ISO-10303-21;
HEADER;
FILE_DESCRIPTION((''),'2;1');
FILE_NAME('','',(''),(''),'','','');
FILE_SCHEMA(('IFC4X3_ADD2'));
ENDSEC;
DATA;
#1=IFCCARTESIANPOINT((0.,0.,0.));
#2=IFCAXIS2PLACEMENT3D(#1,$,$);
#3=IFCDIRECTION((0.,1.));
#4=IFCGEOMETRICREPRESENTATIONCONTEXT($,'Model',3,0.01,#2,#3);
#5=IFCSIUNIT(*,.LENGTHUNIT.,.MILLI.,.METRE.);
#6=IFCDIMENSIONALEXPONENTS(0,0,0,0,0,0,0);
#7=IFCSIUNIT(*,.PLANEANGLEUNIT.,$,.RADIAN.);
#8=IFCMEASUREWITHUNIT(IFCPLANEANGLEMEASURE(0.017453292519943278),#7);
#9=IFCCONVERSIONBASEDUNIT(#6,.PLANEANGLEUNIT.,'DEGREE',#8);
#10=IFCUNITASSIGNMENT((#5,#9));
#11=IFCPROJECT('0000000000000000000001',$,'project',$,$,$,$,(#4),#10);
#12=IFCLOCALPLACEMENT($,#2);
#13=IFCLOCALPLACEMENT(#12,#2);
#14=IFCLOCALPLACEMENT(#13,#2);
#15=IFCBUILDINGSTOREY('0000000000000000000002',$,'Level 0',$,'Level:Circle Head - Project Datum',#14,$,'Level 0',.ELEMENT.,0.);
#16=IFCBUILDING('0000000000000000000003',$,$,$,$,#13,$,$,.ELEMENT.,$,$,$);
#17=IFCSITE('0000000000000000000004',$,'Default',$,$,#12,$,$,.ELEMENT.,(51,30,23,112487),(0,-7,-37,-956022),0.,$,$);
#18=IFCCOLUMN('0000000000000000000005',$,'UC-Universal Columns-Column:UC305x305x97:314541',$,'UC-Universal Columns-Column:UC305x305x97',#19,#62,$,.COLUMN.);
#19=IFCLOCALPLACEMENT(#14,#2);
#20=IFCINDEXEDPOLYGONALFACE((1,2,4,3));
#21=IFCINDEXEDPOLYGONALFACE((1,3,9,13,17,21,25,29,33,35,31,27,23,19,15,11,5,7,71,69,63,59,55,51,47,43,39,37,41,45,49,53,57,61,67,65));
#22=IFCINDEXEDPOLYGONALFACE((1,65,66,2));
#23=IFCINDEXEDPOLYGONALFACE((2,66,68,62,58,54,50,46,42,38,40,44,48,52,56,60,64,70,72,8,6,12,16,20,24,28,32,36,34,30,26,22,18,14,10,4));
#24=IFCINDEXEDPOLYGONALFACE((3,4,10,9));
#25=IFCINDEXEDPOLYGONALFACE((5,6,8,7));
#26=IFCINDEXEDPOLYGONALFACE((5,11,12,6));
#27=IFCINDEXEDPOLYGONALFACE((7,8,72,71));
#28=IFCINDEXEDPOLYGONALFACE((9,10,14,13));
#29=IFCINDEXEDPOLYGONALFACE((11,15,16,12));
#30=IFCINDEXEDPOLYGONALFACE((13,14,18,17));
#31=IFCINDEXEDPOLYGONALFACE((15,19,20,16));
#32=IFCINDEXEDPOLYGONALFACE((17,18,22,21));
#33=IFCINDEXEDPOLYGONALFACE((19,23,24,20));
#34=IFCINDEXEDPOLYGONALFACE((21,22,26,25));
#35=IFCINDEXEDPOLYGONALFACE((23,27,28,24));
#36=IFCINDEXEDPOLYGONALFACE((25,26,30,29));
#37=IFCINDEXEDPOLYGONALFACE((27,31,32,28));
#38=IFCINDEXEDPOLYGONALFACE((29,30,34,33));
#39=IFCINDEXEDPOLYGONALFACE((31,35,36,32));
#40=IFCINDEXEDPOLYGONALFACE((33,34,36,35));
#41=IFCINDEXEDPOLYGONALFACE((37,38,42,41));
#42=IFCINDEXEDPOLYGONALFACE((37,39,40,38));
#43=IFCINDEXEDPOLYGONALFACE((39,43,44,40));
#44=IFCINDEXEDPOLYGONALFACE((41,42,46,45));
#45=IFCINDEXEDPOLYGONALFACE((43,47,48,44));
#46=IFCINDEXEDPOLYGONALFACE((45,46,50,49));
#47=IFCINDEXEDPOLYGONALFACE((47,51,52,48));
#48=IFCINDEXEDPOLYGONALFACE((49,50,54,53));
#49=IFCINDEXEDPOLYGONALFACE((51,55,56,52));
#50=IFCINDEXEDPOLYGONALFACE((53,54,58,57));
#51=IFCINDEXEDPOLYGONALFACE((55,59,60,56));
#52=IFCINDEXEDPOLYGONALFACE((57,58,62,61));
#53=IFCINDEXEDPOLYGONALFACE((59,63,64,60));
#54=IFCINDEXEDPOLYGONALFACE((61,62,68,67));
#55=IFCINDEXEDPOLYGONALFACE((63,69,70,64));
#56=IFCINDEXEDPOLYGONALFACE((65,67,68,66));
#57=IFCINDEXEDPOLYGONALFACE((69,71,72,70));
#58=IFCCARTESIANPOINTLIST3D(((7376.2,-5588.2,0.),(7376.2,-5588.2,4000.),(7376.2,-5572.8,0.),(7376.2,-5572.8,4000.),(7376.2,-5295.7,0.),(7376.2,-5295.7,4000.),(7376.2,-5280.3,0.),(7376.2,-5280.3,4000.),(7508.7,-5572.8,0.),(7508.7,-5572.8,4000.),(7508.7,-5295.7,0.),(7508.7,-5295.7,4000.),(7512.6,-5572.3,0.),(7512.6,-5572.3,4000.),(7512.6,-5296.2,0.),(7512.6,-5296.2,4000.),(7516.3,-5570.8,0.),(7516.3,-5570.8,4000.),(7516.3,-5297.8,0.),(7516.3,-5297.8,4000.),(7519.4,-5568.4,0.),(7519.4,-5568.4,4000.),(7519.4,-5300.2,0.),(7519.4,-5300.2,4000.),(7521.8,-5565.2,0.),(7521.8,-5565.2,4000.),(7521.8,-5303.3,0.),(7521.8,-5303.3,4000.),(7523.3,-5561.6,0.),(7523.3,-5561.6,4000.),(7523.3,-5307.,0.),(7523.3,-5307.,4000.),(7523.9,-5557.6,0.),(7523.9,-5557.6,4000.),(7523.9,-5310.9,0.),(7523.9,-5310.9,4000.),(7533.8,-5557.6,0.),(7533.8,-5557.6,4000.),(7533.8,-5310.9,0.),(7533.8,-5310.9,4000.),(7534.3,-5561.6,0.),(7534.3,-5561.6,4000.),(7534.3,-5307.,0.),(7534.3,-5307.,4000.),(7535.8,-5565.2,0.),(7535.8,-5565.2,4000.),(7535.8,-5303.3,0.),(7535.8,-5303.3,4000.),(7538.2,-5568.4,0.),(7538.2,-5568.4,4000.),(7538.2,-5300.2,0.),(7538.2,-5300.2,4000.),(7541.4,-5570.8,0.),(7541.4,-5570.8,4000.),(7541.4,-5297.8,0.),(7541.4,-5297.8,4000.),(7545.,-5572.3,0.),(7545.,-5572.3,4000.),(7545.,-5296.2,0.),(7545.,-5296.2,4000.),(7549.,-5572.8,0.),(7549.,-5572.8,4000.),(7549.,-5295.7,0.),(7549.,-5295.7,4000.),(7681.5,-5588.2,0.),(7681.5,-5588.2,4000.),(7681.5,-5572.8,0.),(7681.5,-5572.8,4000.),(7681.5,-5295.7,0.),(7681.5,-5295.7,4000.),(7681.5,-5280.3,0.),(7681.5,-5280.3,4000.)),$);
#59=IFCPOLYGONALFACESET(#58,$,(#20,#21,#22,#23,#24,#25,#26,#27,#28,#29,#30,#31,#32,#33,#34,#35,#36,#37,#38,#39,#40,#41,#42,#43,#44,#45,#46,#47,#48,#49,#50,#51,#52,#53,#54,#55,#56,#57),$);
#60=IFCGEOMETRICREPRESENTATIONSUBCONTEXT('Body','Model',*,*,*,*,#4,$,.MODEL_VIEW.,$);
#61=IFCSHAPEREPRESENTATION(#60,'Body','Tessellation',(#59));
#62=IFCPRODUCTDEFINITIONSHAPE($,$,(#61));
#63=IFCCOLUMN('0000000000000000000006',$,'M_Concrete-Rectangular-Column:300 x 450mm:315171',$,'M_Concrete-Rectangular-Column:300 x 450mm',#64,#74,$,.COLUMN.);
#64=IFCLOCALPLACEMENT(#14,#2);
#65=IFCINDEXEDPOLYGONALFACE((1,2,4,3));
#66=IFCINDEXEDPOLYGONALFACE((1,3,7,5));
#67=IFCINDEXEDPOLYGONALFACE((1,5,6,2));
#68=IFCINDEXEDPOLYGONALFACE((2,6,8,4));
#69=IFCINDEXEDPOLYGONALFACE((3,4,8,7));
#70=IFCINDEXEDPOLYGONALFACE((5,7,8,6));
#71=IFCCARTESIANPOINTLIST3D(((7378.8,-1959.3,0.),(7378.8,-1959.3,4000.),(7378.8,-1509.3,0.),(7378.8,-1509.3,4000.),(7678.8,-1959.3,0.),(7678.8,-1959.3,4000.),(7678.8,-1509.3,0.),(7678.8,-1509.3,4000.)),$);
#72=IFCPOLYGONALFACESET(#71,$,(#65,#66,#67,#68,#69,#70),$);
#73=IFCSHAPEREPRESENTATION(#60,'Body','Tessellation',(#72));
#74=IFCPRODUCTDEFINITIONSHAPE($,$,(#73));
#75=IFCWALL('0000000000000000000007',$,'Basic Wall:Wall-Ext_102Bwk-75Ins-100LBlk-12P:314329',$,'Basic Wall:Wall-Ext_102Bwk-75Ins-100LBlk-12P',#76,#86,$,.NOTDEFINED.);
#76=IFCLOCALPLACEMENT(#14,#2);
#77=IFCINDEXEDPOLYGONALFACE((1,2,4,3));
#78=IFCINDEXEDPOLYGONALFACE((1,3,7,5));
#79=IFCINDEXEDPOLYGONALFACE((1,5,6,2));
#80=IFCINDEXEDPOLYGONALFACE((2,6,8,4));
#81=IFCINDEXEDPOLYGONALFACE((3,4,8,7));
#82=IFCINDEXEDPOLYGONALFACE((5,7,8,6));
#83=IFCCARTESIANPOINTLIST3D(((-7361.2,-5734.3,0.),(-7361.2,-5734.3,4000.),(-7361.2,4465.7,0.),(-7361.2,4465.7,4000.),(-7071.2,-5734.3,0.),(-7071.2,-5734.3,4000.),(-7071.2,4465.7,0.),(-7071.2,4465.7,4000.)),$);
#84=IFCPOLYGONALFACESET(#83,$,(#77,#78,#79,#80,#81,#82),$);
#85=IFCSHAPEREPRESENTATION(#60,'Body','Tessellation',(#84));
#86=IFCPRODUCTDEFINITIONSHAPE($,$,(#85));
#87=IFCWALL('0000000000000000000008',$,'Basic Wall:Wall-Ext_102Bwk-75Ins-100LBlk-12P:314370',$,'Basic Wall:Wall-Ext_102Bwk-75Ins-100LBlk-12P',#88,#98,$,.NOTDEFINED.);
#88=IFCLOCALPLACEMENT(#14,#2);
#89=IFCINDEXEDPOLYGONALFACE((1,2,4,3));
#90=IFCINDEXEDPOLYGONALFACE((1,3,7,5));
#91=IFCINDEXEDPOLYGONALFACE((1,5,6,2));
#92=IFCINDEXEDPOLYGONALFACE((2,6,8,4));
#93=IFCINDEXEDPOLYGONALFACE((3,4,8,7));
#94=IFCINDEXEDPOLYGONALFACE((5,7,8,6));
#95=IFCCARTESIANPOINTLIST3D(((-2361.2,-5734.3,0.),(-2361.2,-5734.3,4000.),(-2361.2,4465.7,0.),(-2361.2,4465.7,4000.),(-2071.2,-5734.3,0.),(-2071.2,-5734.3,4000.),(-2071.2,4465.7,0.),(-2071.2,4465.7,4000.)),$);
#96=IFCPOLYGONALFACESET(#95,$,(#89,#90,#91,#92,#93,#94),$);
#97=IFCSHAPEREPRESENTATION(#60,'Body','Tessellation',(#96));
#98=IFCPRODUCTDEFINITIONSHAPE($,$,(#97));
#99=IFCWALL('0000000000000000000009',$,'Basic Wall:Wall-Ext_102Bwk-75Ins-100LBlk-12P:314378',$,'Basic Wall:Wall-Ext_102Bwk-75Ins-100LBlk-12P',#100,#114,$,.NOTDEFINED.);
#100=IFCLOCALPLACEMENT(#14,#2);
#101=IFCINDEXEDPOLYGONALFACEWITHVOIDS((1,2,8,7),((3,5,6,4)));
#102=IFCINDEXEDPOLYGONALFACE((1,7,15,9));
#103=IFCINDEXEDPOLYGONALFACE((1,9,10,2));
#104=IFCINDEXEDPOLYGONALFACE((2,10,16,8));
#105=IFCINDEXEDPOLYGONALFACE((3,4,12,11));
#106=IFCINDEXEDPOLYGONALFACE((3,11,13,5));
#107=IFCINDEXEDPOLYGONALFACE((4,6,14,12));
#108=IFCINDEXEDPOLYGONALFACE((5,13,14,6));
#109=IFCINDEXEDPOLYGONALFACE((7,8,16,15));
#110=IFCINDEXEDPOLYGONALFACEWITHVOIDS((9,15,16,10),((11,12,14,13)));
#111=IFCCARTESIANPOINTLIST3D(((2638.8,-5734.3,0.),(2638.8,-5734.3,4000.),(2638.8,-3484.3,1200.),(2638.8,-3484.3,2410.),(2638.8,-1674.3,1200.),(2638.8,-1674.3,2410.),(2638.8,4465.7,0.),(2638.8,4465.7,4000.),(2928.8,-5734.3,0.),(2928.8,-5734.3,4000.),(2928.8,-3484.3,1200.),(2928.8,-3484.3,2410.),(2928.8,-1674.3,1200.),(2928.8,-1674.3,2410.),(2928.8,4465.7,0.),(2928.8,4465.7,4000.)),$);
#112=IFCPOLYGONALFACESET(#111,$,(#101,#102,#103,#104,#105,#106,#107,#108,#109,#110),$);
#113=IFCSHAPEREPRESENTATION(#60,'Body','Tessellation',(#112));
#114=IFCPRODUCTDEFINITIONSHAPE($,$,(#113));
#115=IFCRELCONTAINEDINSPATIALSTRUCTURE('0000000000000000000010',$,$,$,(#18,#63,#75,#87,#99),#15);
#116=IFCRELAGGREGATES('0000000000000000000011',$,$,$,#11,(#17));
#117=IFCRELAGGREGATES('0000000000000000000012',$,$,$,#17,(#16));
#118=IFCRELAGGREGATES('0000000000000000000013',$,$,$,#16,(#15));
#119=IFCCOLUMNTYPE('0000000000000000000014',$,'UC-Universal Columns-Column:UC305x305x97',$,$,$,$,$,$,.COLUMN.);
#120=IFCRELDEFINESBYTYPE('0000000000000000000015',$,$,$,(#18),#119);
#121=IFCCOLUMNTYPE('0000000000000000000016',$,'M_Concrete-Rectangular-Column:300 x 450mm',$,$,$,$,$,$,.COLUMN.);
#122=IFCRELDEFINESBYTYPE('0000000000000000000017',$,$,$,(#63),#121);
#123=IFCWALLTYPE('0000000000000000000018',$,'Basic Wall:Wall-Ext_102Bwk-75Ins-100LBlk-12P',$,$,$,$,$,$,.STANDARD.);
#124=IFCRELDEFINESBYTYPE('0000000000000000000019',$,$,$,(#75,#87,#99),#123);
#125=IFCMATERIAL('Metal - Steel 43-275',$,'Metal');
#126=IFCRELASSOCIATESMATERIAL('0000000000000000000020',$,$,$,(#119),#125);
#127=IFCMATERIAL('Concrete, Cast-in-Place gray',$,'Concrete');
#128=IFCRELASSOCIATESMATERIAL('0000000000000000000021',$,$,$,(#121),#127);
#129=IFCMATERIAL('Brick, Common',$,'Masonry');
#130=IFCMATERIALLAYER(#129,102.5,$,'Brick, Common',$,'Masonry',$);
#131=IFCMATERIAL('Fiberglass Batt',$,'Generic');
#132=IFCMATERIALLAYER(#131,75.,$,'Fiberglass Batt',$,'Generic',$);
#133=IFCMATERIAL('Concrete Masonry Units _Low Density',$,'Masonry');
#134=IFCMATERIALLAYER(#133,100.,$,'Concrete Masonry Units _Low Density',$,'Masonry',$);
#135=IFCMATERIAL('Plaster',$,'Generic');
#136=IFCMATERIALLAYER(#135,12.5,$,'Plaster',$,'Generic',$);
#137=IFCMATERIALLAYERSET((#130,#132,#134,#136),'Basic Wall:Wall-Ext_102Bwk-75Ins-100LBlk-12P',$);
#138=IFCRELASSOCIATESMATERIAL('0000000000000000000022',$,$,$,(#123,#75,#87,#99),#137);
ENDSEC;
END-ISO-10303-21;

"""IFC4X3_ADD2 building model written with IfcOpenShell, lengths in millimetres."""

from ifc_helpers import new_model, entity, si_unit, converted_unit, direction, frame, frame_2d, origin, origin_2d_with_axis, place, context, subcontext, project, spatial, rectangle, i_section, extrude, source, transform, mapped, material, layer, layer_set, material_profile, profile_set, type_object, type_shapes, element, save


model = new_model("IFC4X3_ADD2")

# Units and contexts
model_context = context("Model", 3, precision=0.01, world=origin(), true_north=direction((0.0, 1.0)))
body_context = subcontext(model_context, "Body", "Model", "MODEL_VIEW")
ifc_project = project(units=[si_unit("LENGTHUNIT", "METRE", prefix="MILLI"), converted_unit("PLANEANGLEUNIT", "DEGREE", entity("IfcPlaneAngleMeasure", 0.017453292519943278), si_unit("PLANEANGLEUNIT", "RADIAN"), dimensions=[0, 0, 0, 0, 0, 0, 0])], contexts=[model_context])

# Site, building, storey
site_placement = place(None, origin())
site = spatial("IfcSite", under=ifc_project, at=site_placement, Name="Default", CompositionType="ELEMENT", RefLatitude=(51, 30, 23, 112487), RefLongitude=(0, -7, -37, -956022), RefElevation=0.0)
building_placement = place(site_placement, origin())
building = spatial("IfcBuilding", under=site, at=building_placement, CompositionType="ELEMENT")
storey_placement = place(building_placement, origin())
storey = spatial("IfcBuildingStorey", under=building, at=storey_placement, Name="Level 0", ObjectType="Level:Circle Head - Project Datum", LongName="Level 0", CompositionType="ELEMENT", Elevation=0.0)

# Columns
ifc_material_1 = material(Name="Metal - Steel 43-275", Category="Metal")
ifc_material_profile_1 = material_profile(ifc_material_1, i_section(OverallWidth=305.3, OverallDepth=307.9, WebThickness=9.9, FlangeThickness=15.4, FilletRadius=15.2, at=origin_2d_with_axis()), Name="UC305x305x97")
ifc_profile_set_1 = profile_set([ifc_material_profile_1], Name="UC305x305x97")
column_type_1 = type_object("IfcColumnType", Name="UC-Universal Columns-Column:UC305x305x97", PredefinedType="COLUMN", material=ifc_profile_set_1)
shared_shape_1 = source(origin(), body_context, "Body", "SweptSolid", [
    extrude(i_section(OverallWidth=305.3, OverallDepth=307.9, WebThickness=9.9, FlangeThickness=15.4, FilletRadius=15.2, at=origin_2d_with_axis()), frame((0.0, 0.0, 0.0), z_axis=(0.0, 0.0, 1.0), x_axis=(-1.0, 0.0, 0.0)), (0.0, 0.0, 1.0), 4000.0),
])
type_shapes(column_type_1, [shared_shape_1])
column_1_placement = place(storey_placement, frame((7528.8, -5434.3, 0.0)))
element("IfcColumn", 1, at=column_1_placement, inside=storey, type_object=column_type_1, Name="UC-Universal Columns-Column:UC305x305x97:314541", ObjectType="UC-Universal Columns-Column:UC305x305x97", PredefinedType="COLUMN", context=body_context, shape_type="MappedRepresentation", body=[
    mapped(shared_shape_1, transform((0.0, 0.0, 0.0), scale=1.0)),
])
ifc_material_2 = material(Name="Concrete, Cast-in-Place gray", Category="Concrete")
ifc_material_profile_2 = material_profile(ifc_material_2, rectangle(XDim=300.0, YDim=450.0, at=origin_2d_with_axis()), Name="300 x 450mm")
ifc_profile_set_2 = profile_set([ifc_material_profile_2], Name="300 x 450mm")
column_type_2 = type_object("IfcColumnType", Name="M_Concrete-Rectangular-Column:300 x 450mm", PredefinedType="COLUMN", material=ifc_profile_set_2)
shared_shape_2 = source(origin(), body_context, "Body", "SweptSolid", [
    extrude(rectangle(XDim=300.0, YDim=450.0, at=origin_2d_with_axis()), frame((0.0, 0.0, 0.0), z_axis=(0.0, 0.0, 1.0), x_axis=(-1.0, 0.0, 0.0)), (0.0, 0.0, 1.0), 4000.0),
])
type_shapes(column_type_2, [shared_shape_2])
column_2_placement = place(storey_placement, frame((7528.8, -1734.3, 0.0)))
element("IfcColumn", 2, at=column_2_placement, inside=storey, type_object=column_type_2, Name="M_Concrete-Rectangular-Column:300 x 450mm:315171", ObjectType="M_Concrete-Rectangular-Column:300 x 450mm", PredefinedType="COLUMN", context=body_context, shape_type="MappedRepresentation", body=[
    mapped(shared_shape_2, transform((0.0, 0.0, 0.0), scale=1.0)),
])

# Walls
ifc_material_3 = material(Name="Brick, Common", Category="Masonry")
ifc_layer_1 = layer(ifc_material_3, 102.5, Name="Brick, Common", Category="Masonry")
ifc_material_4 = material(Name="Fiberglass Batt", Category="Generic")
ifc_layer_2 = layer(ifc_material_4, 75.0, Name="Fiberglass Batt", Category="Generic")
ifc_material_5 = material(Name="Concrete Masonry Units _Low Density", Category="Masonry")
ifc_layer_3 = layer(ifc_material_5, 100.0, Name="Concrete Masonry Units _Low Density", Category="Masonry")
ifc_material_6 = material(Name="Plaster", Category="Generic")
ifc_layer_4 = layer(ifc_material_6, 12.5, Name="Plaster", Category="Generic")
ifc_layer_set = layer_set([ifc_layer_1, ifc_layer_2, ifc_layer_3, ifc_layer_4], Name="Basic Wall:Wall-Ext_102Bwk-75Ins-100LBlk-12P")
wall_type = type_object("IfcWallType", Name="Basic Wall:Wall-Ext_102Bwk-75Ins-100LBlk-12P", PredefinedType="STANDARD", material=ifc_layer_set)
wall_1_placement = place(storey_placement, frame((-7216.2, -5734.3, 0.0), z_axis=(0.0, 0.0, 1.0), x_axis=(0.0, 1.0, 0.0)))
element("IfcWall", 3, at=wall_1_placement, inside=storey, type_object=wall_type, material=ifc_layer_set, Name="Basic Wall:Wall-Ext_102Bwk-75Ins-100LBlk-12P:314329", ObjectType="Basic Wall:Wall-Ext_102Bwk-75Ins-100LBlk-12P", PredefinedType="NOTDEFINED", context=body_context, shape_type="SweptSolid", body=[
    extrude(rectangle(XDim=10200.0, YDim=290.0, at=frame_2d((5100.0, 0.0), x_axis=(-1.0, 0.0))), origin(), (0.0, 0.0, 1.0), 4000.0),
])
wall_2_placement = place(storey_placement, frame((-2216.2, -5734.3, 0.0), z_axis=(0.0, 0.0, 1.0), x_axis=(0.0, 1.0, 0.0)))
element("IfcWall", 4, at=wall_2_placement, inside=storey, type_object=wall_type, material=ifc_layer_set, Name="Basic Wall:Wall-Ext_102Bwk-75Ins-100LBlk-12P:314370", ObjectType="Basic Wall:Wall-Ext_102Bwk-75Ins-100LBlk-12P", PredefinedType="NOTDEFINED", context=body_context, shape_type="SweptSolid", body=[
    extrude(rectangle(XDim=10200.0, YDim=290.0, at=frame_2d((5100.0, 0.0), x_axis=(-1.0, 0.0))), origin(), (0.0, 0.0, 1.0), 4000.0),
])

# Wall, opening
wall_3_placement = place(storey_placement, frame((2783.8, -5734.3, 0.0), z_axis=(0.0, 0.0, 1.0), x_axis=(0.0, 1.0, 0.0)))
wall_3 = element("IfcWall", 5, at=wall_3_placement, inside=storey, type_object=wall_type, material=ifc_layer_set, Name="Basic Wall:Wall-Ext_102Bwk-75Ins-100LBlk-12P:314378", ObjectType="Basic Wall:Wall-Ext_102Bwk-75Ins-100LBlk-12P", PredefinedType="NOTDEFINED", context=body_context, shape_type="SweptSolid", body=[
    extrude(rectangle(XDim=10200.0, YDim=290.0, at=frame_2d((5100.0, 0.0), x_axis=(-1.0, 0.0))), origin(), (0.0, 0.0, 1.0), 4000.0),
])
opening_placement = place(wall_3_placement, frame((2250.0, -145.0, 1200.0)))
element("IfcOpeningElement", 6, at=opening_placement, cuts=wall_3, PredefinedType="OPENING", context=body_context, shape_type="SweptSolid", body=[
    extrude(rectangle(XDim=1210.0, YDim=1810.0, at=frame_2d((605.0, 905.0), x_axis=(-1.0, 0.0))), frame((0.0, 0.0, 0.0), z_axis=(0.0, 1.0, 0.0), x_axis=(0.0, 0.0, 1.0)), (0.0, 0.0, 1.0), 290.0),
])

save(model, "model.ifc")
